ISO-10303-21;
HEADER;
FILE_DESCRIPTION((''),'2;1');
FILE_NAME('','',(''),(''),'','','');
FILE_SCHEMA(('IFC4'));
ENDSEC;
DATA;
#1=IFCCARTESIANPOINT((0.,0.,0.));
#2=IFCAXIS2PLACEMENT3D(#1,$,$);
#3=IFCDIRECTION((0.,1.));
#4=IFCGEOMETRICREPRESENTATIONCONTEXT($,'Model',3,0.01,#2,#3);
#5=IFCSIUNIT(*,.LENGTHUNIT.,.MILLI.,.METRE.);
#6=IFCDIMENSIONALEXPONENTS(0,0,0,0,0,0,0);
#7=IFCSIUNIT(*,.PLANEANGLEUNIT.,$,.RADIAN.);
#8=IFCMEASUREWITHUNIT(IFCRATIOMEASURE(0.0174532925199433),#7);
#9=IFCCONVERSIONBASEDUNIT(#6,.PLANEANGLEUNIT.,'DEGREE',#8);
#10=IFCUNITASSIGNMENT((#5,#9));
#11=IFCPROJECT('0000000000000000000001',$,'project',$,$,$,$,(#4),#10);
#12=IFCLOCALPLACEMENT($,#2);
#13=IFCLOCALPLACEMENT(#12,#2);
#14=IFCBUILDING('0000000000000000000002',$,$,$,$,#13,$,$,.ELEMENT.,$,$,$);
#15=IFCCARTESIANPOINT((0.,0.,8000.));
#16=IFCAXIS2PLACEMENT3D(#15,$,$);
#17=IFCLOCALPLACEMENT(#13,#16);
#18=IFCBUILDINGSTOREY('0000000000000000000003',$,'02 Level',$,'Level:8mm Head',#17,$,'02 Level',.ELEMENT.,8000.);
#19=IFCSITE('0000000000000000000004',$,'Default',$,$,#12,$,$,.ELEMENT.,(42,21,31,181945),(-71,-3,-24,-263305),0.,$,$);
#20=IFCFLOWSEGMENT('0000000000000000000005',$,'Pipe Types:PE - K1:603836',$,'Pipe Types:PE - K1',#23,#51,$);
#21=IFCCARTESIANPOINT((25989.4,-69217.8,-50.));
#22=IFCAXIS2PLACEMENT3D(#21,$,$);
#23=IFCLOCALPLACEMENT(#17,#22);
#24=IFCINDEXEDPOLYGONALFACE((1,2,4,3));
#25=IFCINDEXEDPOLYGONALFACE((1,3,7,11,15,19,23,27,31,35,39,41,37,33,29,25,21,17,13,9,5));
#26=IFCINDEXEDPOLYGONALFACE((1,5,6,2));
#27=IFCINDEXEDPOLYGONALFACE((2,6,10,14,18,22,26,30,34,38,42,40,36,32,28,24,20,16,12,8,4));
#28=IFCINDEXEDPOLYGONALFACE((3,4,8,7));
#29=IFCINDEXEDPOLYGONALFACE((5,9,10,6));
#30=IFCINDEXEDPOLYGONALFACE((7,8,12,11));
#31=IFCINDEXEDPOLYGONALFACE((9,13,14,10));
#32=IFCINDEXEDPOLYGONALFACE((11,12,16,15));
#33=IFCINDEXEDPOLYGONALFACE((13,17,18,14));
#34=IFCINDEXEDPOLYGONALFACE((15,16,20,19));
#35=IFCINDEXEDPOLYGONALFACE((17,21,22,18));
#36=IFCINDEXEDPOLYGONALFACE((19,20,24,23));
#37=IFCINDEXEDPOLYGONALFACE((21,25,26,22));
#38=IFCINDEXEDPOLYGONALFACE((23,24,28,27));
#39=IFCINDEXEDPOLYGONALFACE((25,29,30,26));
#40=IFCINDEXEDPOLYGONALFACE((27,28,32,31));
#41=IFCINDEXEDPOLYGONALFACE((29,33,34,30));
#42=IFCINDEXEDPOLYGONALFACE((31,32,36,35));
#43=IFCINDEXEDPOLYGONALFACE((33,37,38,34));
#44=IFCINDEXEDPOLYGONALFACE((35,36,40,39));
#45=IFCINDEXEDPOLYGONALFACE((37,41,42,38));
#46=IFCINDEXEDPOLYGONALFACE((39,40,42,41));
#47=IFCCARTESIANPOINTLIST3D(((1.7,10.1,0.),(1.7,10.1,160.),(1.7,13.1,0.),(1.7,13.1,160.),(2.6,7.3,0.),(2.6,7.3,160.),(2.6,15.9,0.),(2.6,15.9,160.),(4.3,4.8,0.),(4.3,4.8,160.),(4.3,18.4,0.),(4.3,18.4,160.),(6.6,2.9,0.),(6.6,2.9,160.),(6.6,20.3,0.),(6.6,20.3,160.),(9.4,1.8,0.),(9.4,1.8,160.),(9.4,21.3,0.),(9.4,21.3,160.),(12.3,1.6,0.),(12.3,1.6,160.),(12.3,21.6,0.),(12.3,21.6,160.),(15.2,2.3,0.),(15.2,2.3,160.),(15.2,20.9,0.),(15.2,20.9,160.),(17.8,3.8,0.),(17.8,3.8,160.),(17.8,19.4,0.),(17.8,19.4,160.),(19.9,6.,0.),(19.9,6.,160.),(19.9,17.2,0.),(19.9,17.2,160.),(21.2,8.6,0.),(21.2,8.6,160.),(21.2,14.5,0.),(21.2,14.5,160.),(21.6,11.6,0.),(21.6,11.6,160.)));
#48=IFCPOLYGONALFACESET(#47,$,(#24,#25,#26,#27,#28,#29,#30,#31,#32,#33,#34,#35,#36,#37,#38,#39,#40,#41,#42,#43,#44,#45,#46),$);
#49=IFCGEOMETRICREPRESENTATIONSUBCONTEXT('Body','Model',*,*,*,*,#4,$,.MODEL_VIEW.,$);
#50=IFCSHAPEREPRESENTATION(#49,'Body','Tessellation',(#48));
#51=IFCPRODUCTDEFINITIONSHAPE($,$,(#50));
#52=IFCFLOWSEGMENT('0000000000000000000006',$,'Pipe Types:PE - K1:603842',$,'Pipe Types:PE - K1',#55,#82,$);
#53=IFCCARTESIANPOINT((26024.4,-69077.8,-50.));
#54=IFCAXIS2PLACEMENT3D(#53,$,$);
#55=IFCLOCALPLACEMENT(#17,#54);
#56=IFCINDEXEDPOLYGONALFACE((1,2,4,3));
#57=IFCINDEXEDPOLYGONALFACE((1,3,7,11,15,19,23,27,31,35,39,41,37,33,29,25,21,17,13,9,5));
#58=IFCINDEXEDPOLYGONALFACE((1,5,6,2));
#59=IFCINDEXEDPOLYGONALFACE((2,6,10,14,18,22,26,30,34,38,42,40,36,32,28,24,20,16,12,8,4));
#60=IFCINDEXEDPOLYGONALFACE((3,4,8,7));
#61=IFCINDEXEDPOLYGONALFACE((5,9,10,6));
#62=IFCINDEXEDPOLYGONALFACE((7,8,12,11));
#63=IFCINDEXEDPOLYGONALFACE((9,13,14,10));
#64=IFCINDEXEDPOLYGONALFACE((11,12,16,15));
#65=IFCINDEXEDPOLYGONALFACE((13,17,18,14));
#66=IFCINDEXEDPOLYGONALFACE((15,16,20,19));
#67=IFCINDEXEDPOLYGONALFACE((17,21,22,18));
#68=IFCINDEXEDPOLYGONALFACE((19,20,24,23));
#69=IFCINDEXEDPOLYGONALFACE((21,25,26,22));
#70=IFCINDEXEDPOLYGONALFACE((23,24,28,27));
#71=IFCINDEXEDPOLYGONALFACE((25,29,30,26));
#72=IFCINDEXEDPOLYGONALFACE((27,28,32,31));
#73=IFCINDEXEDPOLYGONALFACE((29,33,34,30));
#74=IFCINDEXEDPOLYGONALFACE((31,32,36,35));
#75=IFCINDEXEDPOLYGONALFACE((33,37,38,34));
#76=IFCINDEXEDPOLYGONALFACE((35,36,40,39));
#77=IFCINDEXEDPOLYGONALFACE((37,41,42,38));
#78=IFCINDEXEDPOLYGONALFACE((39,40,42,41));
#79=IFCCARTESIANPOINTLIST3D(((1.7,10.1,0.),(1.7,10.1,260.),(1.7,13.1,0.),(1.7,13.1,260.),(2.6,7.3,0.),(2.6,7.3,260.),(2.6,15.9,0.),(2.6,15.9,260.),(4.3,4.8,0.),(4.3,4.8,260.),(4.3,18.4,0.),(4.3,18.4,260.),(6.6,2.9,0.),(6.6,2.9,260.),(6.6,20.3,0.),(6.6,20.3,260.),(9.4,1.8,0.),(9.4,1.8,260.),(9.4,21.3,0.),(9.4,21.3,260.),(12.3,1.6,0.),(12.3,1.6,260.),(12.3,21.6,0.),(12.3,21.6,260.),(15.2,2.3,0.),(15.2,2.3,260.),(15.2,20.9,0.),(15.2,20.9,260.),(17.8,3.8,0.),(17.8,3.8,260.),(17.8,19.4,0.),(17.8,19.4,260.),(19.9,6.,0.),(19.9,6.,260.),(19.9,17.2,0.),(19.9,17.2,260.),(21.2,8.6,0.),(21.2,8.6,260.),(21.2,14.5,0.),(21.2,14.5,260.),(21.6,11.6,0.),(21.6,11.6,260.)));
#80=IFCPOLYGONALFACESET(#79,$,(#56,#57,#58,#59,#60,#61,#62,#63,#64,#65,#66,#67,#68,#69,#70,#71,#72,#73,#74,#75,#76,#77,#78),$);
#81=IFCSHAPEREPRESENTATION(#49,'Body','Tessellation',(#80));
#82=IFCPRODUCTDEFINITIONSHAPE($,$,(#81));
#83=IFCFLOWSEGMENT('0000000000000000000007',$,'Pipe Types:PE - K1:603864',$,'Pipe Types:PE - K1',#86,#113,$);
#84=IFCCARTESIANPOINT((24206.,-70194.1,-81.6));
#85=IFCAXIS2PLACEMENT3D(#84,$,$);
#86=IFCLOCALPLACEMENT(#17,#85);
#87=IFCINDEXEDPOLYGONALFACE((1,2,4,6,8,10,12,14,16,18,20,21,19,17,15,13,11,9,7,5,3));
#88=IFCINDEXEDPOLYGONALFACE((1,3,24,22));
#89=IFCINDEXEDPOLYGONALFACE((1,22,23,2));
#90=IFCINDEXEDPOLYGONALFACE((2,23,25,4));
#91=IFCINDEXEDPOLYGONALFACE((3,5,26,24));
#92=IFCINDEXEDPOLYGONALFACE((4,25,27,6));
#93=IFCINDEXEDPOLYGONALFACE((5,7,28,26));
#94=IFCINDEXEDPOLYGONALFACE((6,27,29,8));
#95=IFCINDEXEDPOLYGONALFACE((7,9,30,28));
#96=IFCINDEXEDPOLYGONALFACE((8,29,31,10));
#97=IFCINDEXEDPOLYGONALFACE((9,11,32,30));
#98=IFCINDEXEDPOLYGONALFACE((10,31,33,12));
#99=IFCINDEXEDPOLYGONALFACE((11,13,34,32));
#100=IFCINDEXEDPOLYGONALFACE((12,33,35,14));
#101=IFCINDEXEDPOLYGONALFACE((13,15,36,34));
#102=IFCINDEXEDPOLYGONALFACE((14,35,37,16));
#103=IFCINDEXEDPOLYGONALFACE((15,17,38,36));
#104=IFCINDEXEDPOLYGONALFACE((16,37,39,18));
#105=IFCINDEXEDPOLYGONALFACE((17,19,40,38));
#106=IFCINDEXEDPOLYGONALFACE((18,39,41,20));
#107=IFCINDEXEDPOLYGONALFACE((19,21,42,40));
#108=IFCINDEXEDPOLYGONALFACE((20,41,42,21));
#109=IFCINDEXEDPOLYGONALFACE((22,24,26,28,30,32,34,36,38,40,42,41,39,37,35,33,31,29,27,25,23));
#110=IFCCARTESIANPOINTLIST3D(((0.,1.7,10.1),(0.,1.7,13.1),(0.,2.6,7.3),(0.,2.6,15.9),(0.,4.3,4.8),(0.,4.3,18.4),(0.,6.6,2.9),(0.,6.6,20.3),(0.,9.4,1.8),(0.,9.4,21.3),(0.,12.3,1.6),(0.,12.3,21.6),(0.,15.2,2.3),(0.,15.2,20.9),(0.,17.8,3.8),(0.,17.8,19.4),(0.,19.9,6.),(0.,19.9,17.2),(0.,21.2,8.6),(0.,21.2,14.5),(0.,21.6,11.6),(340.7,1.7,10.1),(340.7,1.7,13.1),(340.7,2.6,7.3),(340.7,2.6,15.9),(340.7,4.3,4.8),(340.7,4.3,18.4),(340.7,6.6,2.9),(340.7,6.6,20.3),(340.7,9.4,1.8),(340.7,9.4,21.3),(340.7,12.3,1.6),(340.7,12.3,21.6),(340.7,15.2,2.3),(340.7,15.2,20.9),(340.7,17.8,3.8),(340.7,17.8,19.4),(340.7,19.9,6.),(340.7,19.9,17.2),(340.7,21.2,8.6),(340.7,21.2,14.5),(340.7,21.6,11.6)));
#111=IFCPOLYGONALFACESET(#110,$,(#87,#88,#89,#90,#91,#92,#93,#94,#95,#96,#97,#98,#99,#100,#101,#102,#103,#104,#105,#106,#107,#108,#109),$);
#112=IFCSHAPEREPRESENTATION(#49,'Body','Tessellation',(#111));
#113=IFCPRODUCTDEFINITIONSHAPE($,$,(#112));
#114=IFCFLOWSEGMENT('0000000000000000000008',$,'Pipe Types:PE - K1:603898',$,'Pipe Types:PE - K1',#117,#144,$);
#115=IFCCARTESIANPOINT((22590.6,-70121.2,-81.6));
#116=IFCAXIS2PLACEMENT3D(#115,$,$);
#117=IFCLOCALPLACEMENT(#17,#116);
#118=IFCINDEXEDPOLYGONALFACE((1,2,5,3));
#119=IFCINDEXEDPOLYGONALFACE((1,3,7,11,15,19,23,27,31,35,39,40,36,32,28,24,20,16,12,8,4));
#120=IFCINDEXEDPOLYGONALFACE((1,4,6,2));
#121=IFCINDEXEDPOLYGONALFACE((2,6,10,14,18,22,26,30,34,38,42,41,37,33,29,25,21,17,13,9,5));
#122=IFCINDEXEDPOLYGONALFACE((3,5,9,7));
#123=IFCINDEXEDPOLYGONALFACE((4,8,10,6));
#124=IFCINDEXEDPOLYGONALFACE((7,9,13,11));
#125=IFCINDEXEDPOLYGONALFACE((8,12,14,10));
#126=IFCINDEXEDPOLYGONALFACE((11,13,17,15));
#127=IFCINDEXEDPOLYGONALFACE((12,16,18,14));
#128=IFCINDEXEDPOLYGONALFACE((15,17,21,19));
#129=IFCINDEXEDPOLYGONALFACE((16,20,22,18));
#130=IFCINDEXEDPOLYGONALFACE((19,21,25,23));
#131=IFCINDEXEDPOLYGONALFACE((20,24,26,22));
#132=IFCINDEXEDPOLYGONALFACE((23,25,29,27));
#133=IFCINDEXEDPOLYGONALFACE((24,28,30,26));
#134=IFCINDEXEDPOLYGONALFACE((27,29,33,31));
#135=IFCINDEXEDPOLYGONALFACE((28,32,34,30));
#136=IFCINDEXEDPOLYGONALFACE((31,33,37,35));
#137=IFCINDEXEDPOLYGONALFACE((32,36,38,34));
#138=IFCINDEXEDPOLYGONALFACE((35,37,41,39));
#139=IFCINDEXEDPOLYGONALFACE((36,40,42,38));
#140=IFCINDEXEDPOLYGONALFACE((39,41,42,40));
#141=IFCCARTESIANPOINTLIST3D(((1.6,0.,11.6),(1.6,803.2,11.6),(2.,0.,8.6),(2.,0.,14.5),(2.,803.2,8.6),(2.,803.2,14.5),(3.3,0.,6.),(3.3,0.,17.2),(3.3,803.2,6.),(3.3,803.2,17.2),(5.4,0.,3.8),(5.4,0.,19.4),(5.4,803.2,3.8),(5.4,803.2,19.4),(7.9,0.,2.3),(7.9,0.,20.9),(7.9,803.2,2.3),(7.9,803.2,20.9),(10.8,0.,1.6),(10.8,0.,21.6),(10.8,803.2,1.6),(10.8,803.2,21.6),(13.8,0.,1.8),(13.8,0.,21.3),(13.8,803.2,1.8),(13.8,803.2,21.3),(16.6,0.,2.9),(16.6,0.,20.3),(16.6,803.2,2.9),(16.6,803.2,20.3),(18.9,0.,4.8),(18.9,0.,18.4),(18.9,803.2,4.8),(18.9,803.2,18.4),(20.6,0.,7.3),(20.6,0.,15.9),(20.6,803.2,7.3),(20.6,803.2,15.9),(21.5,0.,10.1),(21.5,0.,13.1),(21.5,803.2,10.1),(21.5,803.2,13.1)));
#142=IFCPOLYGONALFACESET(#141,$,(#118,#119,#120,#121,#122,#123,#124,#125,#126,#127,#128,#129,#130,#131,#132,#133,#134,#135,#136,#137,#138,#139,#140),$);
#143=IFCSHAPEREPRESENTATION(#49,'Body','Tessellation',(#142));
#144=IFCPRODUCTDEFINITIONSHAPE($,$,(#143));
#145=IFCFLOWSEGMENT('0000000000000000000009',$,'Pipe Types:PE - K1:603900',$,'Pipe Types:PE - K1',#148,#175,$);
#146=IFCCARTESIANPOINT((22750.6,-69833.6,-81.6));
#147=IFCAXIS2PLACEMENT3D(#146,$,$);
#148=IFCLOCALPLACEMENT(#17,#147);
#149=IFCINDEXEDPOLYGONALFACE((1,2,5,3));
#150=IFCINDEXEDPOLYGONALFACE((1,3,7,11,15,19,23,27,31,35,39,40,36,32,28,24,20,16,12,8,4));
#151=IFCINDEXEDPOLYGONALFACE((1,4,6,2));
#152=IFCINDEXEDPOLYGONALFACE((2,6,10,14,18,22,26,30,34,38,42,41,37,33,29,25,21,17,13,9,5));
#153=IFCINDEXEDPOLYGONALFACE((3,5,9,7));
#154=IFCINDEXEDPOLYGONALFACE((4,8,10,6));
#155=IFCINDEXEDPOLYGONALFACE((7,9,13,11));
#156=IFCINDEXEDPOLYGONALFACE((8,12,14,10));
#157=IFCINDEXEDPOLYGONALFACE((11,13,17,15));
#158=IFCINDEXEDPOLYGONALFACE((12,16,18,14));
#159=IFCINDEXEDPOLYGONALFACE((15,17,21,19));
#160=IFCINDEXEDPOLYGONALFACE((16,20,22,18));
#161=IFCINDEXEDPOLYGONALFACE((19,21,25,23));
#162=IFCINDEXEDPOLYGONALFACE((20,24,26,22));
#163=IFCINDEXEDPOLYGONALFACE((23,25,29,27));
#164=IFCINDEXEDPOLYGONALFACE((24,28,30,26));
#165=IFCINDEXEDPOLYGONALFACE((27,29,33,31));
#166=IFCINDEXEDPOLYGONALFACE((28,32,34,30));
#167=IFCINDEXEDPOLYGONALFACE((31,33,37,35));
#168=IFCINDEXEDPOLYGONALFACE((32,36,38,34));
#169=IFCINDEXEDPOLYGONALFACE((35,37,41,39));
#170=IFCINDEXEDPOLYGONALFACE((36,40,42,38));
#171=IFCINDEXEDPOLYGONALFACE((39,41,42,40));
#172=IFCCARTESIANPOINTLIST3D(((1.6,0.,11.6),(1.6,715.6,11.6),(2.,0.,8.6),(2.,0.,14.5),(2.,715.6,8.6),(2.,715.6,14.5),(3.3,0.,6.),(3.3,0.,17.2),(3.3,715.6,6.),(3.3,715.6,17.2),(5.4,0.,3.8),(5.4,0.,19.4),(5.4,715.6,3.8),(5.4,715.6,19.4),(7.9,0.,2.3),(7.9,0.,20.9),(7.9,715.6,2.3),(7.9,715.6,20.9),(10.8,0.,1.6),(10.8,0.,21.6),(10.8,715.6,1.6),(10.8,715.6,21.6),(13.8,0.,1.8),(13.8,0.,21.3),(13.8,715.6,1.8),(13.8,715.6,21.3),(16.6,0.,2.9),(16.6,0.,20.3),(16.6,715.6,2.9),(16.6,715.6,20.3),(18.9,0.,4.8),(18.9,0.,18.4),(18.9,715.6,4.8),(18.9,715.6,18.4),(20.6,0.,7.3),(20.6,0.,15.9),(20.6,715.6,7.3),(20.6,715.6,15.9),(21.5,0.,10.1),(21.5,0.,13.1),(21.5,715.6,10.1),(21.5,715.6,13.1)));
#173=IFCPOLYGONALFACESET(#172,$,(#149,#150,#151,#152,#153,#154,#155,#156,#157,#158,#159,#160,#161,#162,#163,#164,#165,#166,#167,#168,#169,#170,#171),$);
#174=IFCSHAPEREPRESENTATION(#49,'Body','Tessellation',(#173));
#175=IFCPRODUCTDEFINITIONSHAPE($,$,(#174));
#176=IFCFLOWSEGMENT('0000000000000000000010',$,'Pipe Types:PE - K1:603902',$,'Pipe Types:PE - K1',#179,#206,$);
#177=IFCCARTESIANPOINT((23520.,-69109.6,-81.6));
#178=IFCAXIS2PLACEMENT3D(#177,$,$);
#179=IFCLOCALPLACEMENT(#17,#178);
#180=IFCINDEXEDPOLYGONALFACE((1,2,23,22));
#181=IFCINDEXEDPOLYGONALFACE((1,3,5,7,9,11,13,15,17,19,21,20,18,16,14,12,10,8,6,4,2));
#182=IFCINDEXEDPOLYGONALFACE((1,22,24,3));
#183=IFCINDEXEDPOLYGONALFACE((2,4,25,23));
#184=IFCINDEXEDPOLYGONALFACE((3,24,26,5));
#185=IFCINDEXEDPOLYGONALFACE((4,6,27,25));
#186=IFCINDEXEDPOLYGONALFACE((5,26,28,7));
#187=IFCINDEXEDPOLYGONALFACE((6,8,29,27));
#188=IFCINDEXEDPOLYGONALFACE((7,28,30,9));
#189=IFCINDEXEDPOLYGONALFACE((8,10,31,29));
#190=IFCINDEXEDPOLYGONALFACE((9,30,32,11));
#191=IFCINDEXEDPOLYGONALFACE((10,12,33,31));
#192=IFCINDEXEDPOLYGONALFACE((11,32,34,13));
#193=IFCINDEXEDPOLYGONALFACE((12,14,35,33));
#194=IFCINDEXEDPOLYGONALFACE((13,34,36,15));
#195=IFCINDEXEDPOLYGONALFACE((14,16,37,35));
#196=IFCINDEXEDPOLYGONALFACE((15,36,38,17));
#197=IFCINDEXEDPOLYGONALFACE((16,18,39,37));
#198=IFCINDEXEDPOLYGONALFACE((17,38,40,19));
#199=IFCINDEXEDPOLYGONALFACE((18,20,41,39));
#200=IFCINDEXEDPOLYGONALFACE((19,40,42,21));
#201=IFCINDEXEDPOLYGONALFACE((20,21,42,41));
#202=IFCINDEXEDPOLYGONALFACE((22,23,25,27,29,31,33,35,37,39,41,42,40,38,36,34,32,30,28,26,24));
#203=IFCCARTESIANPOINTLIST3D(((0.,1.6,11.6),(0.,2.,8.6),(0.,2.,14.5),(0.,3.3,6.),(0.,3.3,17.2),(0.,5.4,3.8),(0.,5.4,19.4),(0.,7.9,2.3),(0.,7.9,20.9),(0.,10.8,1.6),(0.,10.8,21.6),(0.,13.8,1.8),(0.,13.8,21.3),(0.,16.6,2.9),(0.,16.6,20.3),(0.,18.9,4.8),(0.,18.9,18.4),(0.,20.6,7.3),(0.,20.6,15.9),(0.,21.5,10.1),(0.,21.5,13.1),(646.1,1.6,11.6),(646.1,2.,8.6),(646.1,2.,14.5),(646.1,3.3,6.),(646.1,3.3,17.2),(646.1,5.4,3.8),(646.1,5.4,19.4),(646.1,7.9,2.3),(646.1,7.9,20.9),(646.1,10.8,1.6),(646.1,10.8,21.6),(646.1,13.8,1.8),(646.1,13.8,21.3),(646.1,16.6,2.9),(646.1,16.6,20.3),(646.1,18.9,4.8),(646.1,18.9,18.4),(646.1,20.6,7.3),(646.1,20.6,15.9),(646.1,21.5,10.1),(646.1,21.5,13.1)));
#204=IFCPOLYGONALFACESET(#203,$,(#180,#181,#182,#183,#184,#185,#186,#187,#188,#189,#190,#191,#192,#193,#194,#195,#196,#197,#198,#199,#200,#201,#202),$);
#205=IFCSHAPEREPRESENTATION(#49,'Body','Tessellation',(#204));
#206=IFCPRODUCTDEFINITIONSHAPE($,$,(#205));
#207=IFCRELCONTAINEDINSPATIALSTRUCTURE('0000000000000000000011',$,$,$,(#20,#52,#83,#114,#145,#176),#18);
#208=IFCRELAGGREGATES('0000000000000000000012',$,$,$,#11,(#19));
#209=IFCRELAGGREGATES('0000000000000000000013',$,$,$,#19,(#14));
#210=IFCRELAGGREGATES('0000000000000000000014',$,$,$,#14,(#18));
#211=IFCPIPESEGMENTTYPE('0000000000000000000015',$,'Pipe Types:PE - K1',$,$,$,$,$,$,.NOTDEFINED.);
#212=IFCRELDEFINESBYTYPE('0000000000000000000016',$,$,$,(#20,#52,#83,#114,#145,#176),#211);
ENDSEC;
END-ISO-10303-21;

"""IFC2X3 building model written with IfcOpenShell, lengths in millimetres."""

from ifc_helpers import new_model, entity, si_unit, converted_unit, direction, frame, frame_2d, origin, origin_2d_with_axis, place, context, subcontext, project, spatial, circle, extrude, type_object, element, save


model = new_model("IFC2X3")

# Units and contexts
model_context = context("Model", 3, precision=0.01, world=origin(), true_north=direction((0.0, 1.0)))
body_context = subcontext(model_context, "Body", "Model", "MODEL_VIEW")
ifc_project = project(units=[si_unit("LENGTHUNIT", "METRE", prefix="MILLI"), converted_unit("PLANEANGLEUNIT", "DEGREE", entity("IfcRatioMeasure", 0.0174532925199433), si_unit("PLANEANGLEUNIT", "RADIAN"), dimensions=[0, 0, 0, 0, 0, 0, 0])], contexts=[model_context])

# Site, building, storey
site_placement = place(None, origin())
site = spatial("IfcSite", under=ifc_project, at=site_placement, Name="Default", CompositionType="ELEMENT", RefLatitude=(42, 21, 31, 181945), RefLongitude=(-71, -3, -24, -263305), RefElevation=0.0)
building_placement = place(site_placement, origin())
building = spatial("IfcBuilding", under=site, at=building_placement, CompositionType="ELEMENT")
storey_placement = place(building_placement, frame((0.0, 0.0, 8000.0)))
storey = spatial("IfcBuildingStorey", under=building, at=storey_placement, Name="02 Level", ObjectType="Level:8mm Head", LongName="02 Level", CompositionType="ELEMENT", Elevation=8000.0)

# Flow segments
pipe_segment_type = type_object("IfcPipeSegmentType", Name="Pipe Types:PE - K1", PredefinedType="NOTDEFINED")
flow_segment_1_placement = place(storey_placement, frame((25989.4, -69217.8, -50.0)))
element("IfcFlowSegment", 1, at=flow_segment_1_placement, inside=storey, type_object=pipe_segment_type, Name="Pipe Types:PE - K1:603836", ObjectType="Pipe Types:PE - K1", context=body_context, shape_type="SweptSolid", body=[
    extrude(circle(Radius=10.0, at=origin_2d_with_axis()), frame((11.6, 11.6, 0.0)), (0.0, 0.0, 1.0), 160.0),
])
flow_segment_2_placement = place(storey_placement, frame((26024.4, -69077.8, -50.0)))
element("IfcFlowSegment", 2, at=flow_segment_2_placement, inside=storey, type_object=pipe_segment_type, Name="Pipe Types:PE - K1:603842", ObjectType="Pipe Types:PE - K1", context=body_context, shape_type="SweptSolid", body=[
    extrude(circle(Radius=10.0, at=origin_2d_with_axis()), frame((11.6, 11.6, 0.0)), (0.0, 0.0, 1.0), 260.0),
])
flow_segment_3_placement = place(storey_placement, frame((24206.0, -70194.1, -81.6)))
element("IfcFlowSegment", 3, at=flow_segment_3_placement, inside=storey, type_object=pipe_segment_type, Name="Pipe Types:PE - K1:603864", ObjectType="Pipe Types:PE - K1", context=body_context, shape_type="SweptSolid", body=[
    extrude(circle(Radius=10.0, at=frame_2d((0.0, 0.0), x_axis=(1.0, 0.0))), frame((0.0, 11.6, 11.6), z_axis=(1.0, 0.0, 0.0), x_axis=(0.0, 1.0, 0.0)), (0.0, 0.0, 1.0), 340.7),
])
flow_segment_4_placement = place(storey_placement, frame((22590.6, -70121.2, -81.6)))
element("IfcFlowSegment", 4, at=flow_segment_4_placement, inside=storey, type_object=pipe_segment_type, Name="Pipe Types:PE - K1:603898", ObjectType="Pipe Types:PE - K1", context=body_context, shape_type="SweptSolid", body=[
    extrude(circle(Radius=10.0, at=frame_2d((0.0, 0.0), x_axis=(1.0, 0.0))), frame((11.6, 0.0, 11.6), z_axis=(0.0, 1.0, 0.0), x_axis=(-1.0, 0.0, 0.0)), (0.0, 0.0, 1.0), 803.2),
])
flow_segment_5_placement = place(storey_placement, frame((22750.6, -69833.6, -81.6)))
element("IfcFlowSegment", 5, at=flow_segment_5_placement, inside=storey, type_object=pipe_segment_type, Name="Pipe Types:PE - K1:603900", ObjectType="Pipe Types:PE - K1", context=body_context, shape_type="SweptSolid", body=[
    extrude(circle(Radius=10.0, at=frame_2d((0.0, 0.0), x_axis=(1.0, 0.0))), frame((11.6, 0.0, 11.6), z_axis=(0.0, 1.0, 0.0), x_axis=(-1.0, 0.0, 0.0)), (0.0, 0.0, 1.0), 715.6),
])
flow_segment_6_placement = place(storey_placement, frame((23520.0, -69109.6, -81.6)))
element("IfcFlowSegment", 6, at=flow_segment_6_placement, inside=storey, type_object=pipe_segment_type, Name="Pipe Types:PE - K1:603902", ObjectType="Pipe Types:PE - K1", context=body_context, shape_type="SweptSolid", body=[
    extrude(circle(Radius=10.0, at=origin_2d_with_axis()), frame((0.0, 11.6, 11.6), z_axis=(1.0, 0.0, 0.0), x_axis=(0.0, -1.0, 0.0)), (0.0, 0.0, 1.0), 646.1),
])

save(model, "model.ifc")
